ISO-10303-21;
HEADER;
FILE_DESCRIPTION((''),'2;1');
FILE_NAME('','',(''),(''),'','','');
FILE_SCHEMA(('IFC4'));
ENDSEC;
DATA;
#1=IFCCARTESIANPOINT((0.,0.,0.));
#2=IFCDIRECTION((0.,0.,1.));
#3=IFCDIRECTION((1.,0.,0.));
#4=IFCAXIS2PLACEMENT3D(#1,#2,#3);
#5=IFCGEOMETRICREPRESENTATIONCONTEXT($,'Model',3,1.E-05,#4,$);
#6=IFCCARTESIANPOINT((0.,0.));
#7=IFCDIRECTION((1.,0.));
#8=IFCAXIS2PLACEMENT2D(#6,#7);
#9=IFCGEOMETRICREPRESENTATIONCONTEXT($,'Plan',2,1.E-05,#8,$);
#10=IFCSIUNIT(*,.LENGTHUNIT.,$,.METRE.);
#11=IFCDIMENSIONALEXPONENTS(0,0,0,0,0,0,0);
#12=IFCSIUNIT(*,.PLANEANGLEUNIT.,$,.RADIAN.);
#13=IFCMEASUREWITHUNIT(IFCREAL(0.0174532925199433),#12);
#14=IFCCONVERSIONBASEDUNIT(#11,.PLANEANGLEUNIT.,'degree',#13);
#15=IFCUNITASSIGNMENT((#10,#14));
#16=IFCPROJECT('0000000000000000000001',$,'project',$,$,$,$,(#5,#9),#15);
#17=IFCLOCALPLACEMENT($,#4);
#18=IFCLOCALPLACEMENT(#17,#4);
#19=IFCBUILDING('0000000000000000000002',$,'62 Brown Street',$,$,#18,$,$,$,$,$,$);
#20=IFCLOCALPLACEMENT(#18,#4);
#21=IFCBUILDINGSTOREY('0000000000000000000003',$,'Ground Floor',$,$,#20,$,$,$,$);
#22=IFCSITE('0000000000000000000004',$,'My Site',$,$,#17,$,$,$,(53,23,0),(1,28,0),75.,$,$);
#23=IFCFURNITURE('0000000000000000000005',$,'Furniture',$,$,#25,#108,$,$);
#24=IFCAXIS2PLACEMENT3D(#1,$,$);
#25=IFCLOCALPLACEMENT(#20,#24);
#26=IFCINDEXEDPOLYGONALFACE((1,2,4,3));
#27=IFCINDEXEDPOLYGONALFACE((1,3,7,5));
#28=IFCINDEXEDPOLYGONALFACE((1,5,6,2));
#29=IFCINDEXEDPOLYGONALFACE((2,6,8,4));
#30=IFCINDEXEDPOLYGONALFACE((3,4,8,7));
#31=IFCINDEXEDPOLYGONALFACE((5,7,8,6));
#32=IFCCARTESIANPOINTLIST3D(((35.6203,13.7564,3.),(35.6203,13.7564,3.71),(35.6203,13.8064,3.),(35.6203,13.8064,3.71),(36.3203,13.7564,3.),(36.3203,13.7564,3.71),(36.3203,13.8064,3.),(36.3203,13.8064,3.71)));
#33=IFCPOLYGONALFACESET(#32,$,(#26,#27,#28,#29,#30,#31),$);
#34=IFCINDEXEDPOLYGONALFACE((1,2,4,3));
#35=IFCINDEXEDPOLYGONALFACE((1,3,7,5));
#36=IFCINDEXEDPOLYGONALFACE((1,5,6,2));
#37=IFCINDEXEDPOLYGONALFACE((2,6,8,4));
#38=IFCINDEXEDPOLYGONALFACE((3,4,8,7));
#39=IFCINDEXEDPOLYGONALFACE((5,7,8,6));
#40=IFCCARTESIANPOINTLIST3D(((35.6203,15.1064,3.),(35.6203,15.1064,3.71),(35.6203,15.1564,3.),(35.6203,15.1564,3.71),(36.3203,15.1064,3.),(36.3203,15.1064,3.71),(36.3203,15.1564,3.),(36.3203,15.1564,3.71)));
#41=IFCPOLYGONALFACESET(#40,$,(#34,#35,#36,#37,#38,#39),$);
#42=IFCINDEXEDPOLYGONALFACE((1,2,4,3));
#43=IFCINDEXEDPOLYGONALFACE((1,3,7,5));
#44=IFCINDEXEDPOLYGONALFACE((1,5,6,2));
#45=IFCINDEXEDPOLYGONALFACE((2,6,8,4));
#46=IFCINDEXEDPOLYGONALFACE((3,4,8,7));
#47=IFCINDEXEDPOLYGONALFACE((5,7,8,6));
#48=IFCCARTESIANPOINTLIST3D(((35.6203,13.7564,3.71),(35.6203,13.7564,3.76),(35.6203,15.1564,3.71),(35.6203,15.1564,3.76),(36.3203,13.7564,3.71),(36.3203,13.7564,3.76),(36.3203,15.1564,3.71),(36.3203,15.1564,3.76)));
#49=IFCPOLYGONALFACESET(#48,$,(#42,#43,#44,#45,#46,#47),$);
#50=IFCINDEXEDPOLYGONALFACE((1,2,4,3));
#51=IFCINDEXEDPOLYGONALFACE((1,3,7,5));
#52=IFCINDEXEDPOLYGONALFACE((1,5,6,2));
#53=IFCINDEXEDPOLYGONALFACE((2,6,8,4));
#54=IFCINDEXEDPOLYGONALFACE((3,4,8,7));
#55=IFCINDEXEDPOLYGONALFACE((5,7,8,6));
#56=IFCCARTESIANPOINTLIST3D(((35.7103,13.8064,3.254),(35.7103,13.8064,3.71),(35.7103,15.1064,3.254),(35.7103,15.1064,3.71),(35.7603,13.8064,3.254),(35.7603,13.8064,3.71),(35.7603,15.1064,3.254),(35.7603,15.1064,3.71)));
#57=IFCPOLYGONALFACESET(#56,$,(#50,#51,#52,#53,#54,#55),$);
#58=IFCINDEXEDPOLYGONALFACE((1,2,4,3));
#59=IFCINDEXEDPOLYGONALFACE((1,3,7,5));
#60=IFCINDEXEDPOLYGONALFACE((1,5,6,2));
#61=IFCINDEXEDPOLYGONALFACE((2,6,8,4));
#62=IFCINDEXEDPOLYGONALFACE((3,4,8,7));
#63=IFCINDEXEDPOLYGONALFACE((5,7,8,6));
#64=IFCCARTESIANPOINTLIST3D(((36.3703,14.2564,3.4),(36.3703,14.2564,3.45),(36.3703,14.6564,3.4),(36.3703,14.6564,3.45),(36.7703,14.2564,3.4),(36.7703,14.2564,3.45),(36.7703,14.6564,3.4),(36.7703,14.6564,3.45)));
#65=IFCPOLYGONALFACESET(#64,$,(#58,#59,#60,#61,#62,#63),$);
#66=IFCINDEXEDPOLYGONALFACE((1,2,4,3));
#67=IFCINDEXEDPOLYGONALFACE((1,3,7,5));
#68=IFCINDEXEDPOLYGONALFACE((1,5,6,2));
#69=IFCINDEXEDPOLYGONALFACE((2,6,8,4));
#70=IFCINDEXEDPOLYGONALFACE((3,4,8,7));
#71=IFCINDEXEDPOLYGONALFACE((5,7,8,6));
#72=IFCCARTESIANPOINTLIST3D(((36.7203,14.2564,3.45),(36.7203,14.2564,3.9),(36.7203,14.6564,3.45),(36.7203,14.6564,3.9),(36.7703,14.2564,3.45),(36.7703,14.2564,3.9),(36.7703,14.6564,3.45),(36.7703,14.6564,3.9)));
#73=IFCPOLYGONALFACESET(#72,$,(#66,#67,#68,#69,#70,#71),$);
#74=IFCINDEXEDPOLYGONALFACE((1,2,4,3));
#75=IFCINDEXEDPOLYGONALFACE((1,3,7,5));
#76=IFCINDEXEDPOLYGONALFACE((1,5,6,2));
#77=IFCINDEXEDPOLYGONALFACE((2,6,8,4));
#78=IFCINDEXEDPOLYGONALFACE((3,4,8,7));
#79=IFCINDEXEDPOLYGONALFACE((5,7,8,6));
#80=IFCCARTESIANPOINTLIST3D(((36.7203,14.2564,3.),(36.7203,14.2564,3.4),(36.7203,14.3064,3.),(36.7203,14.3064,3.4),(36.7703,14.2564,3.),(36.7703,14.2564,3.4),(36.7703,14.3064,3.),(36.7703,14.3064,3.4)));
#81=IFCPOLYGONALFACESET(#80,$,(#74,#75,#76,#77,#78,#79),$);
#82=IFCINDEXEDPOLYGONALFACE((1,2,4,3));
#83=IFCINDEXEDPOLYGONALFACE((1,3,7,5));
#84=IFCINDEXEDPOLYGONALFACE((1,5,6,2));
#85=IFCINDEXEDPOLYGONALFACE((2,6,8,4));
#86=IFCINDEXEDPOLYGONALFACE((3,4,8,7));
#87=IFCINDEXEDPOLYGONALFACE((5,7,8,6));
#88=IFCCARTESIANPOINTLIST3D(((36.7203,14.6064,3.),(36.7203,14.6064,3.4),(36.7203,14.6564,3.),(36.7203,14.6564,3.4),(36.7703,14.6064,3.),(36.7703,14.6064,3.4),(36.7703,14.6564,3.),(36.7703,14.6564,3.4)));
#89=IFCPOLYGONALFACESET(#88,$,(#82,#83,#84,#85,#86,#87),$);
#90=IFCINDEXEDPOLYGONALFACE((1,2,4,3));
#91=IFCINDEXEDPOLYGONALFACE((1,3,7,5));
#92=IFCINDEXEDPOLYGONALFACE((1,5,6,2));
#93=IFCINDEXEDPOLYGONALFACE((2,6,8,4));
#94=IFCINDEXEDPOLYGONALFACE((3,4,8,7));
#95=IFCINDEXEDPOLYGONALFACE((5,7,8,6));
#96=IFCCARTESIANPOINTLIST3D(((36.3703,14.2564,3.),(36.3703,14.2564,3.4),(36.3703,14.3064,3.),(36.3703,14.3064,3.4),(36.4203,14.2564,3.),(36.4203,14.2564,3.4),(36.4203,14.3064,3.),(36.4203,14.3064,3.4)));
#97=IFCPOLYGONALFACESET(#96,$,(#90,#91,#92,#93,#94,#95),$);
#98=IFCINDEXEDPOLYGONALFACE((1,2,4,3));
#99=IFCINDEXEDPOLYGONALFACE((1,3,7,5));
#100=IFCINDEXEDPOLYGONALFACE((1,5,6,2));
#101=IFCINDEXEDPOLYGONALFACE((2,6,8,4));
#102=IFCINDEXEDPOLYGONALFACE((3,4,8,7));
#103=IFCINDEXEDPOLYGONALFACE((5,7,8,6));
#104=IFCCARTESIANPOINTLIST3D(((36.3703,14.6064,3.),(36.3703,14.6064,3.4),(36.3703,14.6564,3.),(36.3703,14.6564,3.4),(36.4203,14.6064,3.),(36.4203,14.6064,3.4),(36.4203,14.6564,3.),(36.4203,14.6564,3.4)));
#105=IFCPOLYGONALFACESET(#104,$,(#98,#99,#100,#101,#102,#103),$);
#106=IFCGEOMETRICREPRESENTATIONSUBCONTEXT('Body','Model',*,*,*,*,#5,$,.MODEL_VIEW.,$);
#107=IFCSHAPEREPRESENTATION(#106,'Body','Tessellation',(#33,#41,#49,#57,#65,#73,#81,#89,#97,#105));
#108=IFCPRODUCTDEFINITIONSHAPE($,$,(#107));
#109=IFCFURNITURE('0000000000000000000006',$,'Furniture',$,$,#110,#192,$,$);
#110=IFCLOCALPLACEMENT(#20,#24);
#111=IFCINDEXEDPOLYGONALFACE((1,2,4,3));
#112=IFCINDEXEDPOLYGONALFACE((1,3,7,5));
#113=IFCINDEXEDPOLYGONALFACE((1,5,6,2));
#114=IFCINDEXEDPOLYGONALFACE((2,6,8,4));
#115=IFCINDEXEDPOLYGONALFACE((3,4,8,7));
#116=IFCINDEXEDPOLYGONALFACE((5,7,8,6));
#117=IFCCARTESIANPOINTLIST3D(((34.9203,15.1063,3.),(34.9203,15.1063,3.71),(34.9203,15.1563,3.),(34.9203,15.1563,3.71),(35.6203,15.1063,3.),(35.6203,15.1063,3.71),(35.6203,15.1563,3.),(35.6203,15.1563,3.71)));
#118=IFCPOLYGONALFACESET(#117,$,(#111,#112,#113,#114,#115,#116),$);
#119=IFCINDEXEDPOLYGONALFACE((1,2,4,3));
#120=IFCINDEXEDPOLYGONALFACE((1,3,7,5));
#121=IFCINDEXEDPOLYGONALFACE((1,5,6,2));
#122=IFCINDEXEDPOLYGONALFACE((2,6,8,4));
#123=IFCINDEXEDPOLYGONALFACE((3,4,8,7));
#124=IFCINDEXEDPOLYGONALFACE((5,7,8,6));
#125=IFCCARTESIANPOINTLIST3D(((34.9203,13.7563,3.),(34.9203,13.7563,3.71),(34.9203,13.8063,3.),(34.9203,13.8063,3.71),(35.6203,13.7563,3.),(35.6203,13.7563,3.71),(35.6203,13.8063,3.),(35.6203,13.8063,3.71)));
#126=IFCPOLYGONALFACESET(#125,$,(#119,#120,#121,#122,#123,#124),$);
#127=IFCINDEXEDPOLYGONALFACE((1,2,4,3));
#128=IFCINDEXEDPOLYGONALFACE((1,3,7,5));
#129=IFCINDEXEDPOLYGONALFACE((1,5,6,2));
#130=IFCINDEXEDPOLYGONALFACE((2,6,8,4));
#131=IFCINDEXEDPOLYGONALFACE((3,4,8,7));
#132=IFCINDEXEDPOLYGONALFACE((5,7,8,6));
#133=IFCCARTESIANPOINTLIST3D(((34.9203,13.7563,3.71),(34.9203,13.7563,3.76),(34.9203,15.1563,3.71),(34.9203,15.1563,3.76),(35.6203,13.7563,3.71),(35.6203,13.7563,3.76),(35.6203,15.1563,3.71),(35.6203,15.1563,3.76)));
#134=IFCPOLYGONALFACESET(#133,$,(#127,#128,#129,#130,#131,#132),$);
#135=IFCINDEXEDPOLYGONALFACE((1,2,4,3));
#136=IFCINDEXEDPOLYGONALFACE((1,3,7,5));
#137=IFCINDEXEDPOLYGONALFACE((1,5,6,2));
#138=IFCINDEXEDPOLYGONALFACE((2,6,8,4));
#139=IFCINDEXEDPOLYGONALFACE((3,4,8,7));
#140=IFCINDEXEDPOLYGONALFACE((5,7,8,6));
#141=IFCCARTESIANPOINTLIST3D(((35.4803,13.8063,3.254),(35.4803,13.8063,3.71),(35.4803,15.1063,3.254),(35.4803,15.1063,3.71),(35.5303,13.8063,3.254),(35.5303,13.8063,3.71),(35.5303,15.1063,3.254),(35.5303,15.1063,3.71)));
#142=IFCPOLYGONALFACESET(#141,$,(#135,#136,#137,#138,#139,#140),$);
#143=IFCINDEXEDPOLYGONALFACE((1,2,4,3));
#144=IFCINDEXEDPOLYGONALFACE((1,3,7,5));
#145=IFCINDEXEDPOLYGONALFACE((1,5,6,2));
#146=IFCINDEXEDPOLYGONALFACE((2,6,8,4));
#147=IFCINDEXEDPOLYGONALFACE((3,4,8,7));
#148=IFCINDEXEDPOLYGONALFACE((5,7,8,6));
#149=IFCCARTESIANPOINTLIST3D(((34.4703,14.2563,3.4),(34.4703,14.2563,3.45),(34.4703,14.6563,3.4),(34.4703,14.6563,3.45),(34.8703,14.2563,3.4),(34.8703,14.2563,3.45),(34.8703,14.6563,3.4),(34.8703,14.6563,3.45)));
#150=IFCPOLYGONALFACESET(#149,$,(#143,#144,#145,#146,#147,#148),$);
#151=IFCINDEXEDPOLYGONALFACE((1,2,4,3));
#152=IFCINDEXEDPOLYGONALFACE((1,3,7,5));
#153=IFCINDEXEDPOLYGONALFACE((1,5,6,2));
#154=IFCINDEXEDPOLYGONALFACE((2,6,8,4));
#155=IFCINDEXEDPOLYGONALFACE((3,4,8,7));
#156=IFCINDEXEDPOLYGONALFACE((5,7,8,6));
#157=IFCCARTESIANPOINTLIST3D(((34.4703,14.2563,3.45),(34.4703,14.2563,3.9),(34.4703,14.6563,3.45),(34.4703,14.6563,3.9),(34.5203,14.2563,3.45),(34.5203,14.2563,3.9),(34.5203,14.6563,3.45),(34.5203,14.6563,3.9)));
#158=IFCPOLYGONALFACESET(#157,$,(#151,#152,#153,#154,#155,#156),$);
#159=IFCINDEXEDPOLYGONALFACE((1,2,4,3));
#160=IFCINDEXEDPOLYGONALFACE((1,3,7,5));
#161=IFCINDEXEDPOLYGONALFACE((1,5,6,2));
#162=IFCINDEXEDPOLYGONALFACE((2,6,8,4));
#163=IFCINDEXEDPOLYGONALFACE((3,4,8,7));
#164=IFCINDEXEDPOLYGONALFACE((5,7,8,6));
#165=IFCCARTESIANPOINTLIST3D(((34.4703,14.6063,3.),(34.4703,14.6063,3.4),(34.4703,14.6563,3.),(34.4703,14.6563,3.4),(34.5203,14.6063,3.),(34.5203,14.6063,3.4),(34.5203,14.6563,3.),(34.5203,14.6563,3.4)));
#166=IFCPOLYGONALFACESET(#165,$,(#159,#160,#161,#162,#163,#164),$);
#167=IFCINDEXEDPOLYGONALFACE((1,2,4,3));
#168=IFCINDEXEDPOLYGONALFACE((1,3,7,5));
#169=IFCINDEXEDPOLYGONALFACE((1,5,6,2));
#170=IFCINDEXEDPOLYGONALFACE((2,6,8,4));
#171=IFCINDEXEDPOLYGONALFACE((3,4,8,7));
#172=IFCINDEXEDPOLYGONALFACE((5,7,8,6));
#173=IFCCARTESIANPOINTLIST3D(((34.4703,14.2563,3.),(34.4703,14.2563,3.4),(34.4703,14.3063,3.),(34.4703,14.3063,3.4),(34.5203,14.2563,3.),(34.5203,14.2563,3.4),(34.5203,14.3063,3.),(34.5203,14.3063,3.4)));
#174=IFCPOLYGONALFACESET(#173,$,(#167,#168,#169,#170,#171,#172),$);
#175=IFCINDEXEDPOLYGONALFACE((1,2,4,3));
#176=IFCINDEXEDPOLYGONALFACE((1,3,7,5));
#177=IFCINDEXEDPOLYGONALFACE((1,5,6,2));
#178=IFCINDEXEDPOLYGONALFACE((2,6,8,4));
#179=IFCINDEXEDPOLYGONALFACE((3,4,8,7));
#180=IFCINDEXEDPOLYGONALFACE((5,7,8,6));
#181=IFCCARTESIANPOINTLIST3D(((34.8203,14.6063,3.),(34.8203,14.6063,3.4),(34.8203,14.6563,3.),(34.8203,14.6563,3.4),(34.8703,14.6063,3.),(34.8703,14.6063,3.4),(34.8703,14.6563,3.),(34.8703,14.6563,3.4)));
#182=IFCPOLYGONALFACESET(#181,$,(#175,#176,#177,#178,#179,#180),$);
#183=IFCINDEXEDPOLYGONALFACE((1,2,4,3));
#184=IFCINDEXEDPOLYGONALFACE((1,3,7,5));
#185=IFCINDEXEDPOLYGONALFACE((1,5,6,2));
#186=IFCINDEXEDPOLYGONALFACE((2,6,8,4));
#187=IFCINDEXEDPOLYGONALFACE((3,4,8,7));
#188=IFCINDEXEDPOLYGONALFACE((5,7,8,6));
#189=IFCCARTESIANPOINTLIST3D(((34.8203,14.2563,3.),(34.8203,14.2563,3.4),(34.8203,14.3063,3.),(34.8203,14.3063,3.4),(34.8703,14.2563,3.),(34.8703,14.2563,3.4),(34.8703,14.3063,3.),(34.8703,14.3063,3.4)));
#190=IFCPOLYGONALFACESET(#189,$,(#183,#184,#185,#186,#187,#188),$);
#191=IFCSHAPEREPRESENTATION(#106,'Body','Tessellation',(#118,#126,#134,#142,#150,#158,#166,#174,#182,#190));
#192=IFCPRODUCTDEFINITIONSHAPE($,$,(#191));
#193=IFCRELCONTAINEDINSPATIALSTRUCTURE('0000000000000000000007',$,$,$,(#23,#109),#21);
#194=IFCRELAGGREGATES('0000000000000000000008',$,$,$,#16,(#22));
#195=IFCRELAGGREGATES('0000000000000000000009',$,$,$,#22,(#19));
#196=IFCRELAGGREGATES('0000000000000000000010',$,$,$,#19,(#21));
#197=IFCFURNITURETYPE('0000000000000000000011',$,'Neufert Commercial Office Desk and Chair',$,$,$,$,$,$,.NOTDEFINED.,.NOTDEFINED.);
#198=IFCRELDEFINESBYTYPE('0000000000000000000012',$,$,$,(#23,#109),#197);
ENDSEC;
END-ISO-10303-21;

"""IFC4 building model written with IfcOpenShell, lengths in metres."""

from ifc_helpers import new_model, entity, si_unit, converted_unit, frame, origin_with_axes, origin_2d_with_axis, place, context, subcontext, project, spatial, line, indexed_curve, outline, extrude, shape, source, transform, mapped, type_object, type_shapes, element, save


model = new_model("IFC4")

# Units and contexts
model_context = context("Model", 3, precision=1e-05, world=origin_with_axes())
plan_context = context("Plan", 2, precision=1e-05, world=origin_2d_with_axis())
body_context_1 = subcontext(model_context, "Body", "Model", "MODEL_VIEW")
body_context_2 = subcontext(plan_context, "Body", "Plan", "PLAN_VIEW")
ifc_project = project(units=[si_unit("LENGTHUNIT", "METRE"), converted_unit("PLANEANGLEUNIT", "degree", entity("IfcReal", 0.0174532925199433), si_unit("PLANEANGLEUNIT", "RADIAN"), dimensions=[0, 0, 0, 0, 0, 0, 0])], contexts=[model_context, plan_context])

# Site, building, storey
site_placement = place(None, origin_with_axes())
site = spatial("IfcSite", under=ifc_project, at=site_placement, Name="My Site", RefLatitude=(53, 23, 0), RefLongitude=(1, 28, 0), RefElevation=75.0)
building_placement = place(site_placement, origin_with_axes())
building = spatial("IfcBuilding", under=site, at=building_placement, Name="62 Brown Street")
storey_placement = place(building_placement, origin_with_axes())
storey = spatial("IfcBuildingStorey", under=building, at=storey_placement, Name="Ground Floor")

# Furniture
furniture_type = type_object("IfcFurnitureType", Name="Neufert Commercial Office Desk and Chair", AssemblyPlace="NOTDEFINED", PredefinedType="NOTDEFINED")
shared_shape_1 = source(origin_with_axes(), body_context_1, "Body", "SweptSolid", [
    extrude(outline(indexed_curve([(0.0, 0.0), (0.05, 0.0), (0.05, 0.7), (0.0, 0.7)], segments=[line(1, 2, 3, 4, 1)])), frame((0.0, 0.45, 0.0), z_axis=(0.0, 0.0, 1.0), x_axis=(1.0, 0.0, 0.0)), (0.0, 0.0, 1.0), 0.71),
    extrude(outline(indexed_curve([(0.0, 0.0), (0.05, 0.0), (0.05, 0.7), (0.0, 0.7)], segments=[line(1, 2, 3, 4, 1)])), frame((1.35, 0.45, 0.0), z_axis=(0.0, 0.0, 1.0), x_axis=(1.0, 0.0, 0.0)), (0.0, 0.0, 1.0), 0.71),
    extrude(outline(indexed_curve([(0.0, 0.0), (1.4, 0.0), (1.4, 0.7), (0.0, 0.7)], segments=[line(1, 2, 3, 4, 1)])), frame((0.0, 0.45, 0.71), z_axis=(0.0, 0.0, 1.0), x_axis=(1.0, 0.0, 0.0)), (0.0, 0.0, 1.0), 0.05),
    extrude(outline(indexed_curve([(0.05, 0.56), (1.35, 0.56), (1.35, 0.61), (0.05, 0.61)], segments=[line(1, 2, 3, 4, 1)])), frame((0.0, 0.45, 0.254), z_axis=(0.0, 0.0, 1.0), x_axis=(1.0, 0.0, 0.0)), (0.0, 0.0, 1.0), 0.456),
    extrude(outline(indexed_curve([(-0.2, 0.0), (0.2, 0.0), (0.2, 0.4), (-0.2, 0.4)], segments=[line(1, 2, 3, 4, 1)])), frame((0.7, 0.0, 0.45), z_axis=(0.0, 0.0, 1.0), x_axis=(1.0, 0.0, 0.0)), (0.0, 0.0, -1.0), 0.05),
    extrude(outline(indexed_curve([(-0.2, 0.0), (0.2, 0.0), (0.2, 0.05), (-0.2, 0.05)], segments=[line(1, 2, 3, 4, 1)])), frame((0.7, 0.0, 0.9), z_axis=(0.0, 0.0, 1.0), x_axis=(1.0, 0.0, 0.0)), (0.0, 0.0, -1.0), 0.45),
    extrude(outline(indexed_curve([(-0.2, 0.0), (-0.15, 0.0), (-0.15, 0.05), (-0.2, 0.05)], segments=[line(1, 2, 3, 4, 1)])), frame((0.7, 0.0, 0.0), z_axis=(0.0, 0.0, 1.0), x_axis=(1.0, 0.0, 0.0)), (0.0, 0.0, 1.0), 0.4),
    extrude(outline(indexed_curve([(0.2, 0.0), (0.15, 0.0), (0.15, 0.05), (0.2, 0.05)], segments=[line(1, 2, 3, 4, 1)])), frame((0.7, 0.0, 0.0), z_axis=(0.0, 0.0, 1.0), x_axis=(1.0, 0.0, 0.0)), (0.0, 0.0, 1.0), 0.4),
    extrude(outline(indexed_curve([(-0.2, 0.4), (-0.15, 0.4), (-0.15, 0.35), (-0.2, 0.35)], segments=[line(1, 2, 3, 4, 1)])), frame((0.7, 0.0, 0.0), z_axis=(0.0, 0.0, 1.0), x_axis=(1.0, 0.0, 0.0)), (0.0, 0.0, 1.0), 0.4),
    extrude(outline(indexed_curve([(0.2, 0.4), (0.15, 0.4), (0.15, 0.35), (0.2, 0.35)], segments=[line(1, 2, 3, 4, 1)])), frame((0.7, 0.0, 0.0), z_axis=(0.0, 0.0, 1.0), x_axis=(1.0, 0.0, 0.0)), (0.0, 0.0, 1.0), 0.4),
])
shared_shape_2 = source(origin_with_axes(), body_context_2, "Body", "Curve2D", [
    entity("IfcIndexedPolyCurve", entity("IfcCartesianPointList2D", [[0.0, 0.45], [1.4, 0.45], [1.4, 1.15], [0.0, 1.15]]), [entity("IfcLineIndex", [1, 2, 3, 4, 1])]),
    entity("IfcIndexedPolyCurve", entity("IfcCartesianPointList2D", [[0.5, 0.4], [0.9, 0.4]])),
    entity("IfcIndexedPolyCurve", entity("IfcCartesianPointList2D", [[0.5, 0.4], [0.5, 0.2], [0.5586, 0.0586], [0.7, 0.0], [0.8414, 0.0586], [0.9, 0.2], [0.9, 0.4]]), [entity("IfcLineIndex", [1, 2]), entity("IfcArcIndex", [2, 3, 4]), entity("IfcArcIndex", [4, 5, 6]), entity("IfcLineIndex", [6, 7])]),
    entity("IfcIndexedPolyCurve", entity("IfcCartesianPointList2D", [[0.54, 0.4], [0.54, 0.2], [0.5869, 0.0869], [0.7, 0.04], [0.8131, 0.0869], [0.86, 0.2], [0.86, 0.4]]), [entity("IfcLineIndex", [1, 2]), entity("IfcArcIndex", [2, 3, 4]), entity("IfcArcIndex", [4, 5, 6]), entity("IfcLineIndex", [6, 7])]),
])
type_shapes(furniture_type, [shared_shape_1, shared_shape_2])
for number, where, z_axis, x_axis, name in (
    (1, (36.7703, 13.7564, 3.0), (0.0, 0.0, 1.0), (0.0, 1.0, 0.0), "Furniture"),
    (2, (34.4703, 15.1563, 3.0), (0.0, 0.0, 1.0), (0.0, -1.0, 0.0), "Furniture"),
):
    element("IfcFurniture", number, at=place(storey_placement, frame(where, z_axis=z_axis, x_axis=x_axis)), inside=storey, type_object=furniture_type, Name=name, shapes=[
        shape(body_context_1, "Body", "MappedRepresentation", [mapped(shared_shape_1, transform((0.0, 0.0, 0.0), x_axis=(1.0, 0.0, 0.0), y_axis=(0.0, 1.0, 0.0), z_axis=(0.0, 0.0, 1.0), scale=1.0))]),
        shape(body_context_2, "Body", "MappedRepresentation", [mapped(shared_shape_2, transform((0.0, 0.0, 0.0), x_axis=(1.0, 0.0, 0.0), y_axis=(0.0, 1.0, 0.0), z_axis=(0.0, 0.0, 1.0), scale=1.0))]),
    ])

save(model, "model.ifc")
